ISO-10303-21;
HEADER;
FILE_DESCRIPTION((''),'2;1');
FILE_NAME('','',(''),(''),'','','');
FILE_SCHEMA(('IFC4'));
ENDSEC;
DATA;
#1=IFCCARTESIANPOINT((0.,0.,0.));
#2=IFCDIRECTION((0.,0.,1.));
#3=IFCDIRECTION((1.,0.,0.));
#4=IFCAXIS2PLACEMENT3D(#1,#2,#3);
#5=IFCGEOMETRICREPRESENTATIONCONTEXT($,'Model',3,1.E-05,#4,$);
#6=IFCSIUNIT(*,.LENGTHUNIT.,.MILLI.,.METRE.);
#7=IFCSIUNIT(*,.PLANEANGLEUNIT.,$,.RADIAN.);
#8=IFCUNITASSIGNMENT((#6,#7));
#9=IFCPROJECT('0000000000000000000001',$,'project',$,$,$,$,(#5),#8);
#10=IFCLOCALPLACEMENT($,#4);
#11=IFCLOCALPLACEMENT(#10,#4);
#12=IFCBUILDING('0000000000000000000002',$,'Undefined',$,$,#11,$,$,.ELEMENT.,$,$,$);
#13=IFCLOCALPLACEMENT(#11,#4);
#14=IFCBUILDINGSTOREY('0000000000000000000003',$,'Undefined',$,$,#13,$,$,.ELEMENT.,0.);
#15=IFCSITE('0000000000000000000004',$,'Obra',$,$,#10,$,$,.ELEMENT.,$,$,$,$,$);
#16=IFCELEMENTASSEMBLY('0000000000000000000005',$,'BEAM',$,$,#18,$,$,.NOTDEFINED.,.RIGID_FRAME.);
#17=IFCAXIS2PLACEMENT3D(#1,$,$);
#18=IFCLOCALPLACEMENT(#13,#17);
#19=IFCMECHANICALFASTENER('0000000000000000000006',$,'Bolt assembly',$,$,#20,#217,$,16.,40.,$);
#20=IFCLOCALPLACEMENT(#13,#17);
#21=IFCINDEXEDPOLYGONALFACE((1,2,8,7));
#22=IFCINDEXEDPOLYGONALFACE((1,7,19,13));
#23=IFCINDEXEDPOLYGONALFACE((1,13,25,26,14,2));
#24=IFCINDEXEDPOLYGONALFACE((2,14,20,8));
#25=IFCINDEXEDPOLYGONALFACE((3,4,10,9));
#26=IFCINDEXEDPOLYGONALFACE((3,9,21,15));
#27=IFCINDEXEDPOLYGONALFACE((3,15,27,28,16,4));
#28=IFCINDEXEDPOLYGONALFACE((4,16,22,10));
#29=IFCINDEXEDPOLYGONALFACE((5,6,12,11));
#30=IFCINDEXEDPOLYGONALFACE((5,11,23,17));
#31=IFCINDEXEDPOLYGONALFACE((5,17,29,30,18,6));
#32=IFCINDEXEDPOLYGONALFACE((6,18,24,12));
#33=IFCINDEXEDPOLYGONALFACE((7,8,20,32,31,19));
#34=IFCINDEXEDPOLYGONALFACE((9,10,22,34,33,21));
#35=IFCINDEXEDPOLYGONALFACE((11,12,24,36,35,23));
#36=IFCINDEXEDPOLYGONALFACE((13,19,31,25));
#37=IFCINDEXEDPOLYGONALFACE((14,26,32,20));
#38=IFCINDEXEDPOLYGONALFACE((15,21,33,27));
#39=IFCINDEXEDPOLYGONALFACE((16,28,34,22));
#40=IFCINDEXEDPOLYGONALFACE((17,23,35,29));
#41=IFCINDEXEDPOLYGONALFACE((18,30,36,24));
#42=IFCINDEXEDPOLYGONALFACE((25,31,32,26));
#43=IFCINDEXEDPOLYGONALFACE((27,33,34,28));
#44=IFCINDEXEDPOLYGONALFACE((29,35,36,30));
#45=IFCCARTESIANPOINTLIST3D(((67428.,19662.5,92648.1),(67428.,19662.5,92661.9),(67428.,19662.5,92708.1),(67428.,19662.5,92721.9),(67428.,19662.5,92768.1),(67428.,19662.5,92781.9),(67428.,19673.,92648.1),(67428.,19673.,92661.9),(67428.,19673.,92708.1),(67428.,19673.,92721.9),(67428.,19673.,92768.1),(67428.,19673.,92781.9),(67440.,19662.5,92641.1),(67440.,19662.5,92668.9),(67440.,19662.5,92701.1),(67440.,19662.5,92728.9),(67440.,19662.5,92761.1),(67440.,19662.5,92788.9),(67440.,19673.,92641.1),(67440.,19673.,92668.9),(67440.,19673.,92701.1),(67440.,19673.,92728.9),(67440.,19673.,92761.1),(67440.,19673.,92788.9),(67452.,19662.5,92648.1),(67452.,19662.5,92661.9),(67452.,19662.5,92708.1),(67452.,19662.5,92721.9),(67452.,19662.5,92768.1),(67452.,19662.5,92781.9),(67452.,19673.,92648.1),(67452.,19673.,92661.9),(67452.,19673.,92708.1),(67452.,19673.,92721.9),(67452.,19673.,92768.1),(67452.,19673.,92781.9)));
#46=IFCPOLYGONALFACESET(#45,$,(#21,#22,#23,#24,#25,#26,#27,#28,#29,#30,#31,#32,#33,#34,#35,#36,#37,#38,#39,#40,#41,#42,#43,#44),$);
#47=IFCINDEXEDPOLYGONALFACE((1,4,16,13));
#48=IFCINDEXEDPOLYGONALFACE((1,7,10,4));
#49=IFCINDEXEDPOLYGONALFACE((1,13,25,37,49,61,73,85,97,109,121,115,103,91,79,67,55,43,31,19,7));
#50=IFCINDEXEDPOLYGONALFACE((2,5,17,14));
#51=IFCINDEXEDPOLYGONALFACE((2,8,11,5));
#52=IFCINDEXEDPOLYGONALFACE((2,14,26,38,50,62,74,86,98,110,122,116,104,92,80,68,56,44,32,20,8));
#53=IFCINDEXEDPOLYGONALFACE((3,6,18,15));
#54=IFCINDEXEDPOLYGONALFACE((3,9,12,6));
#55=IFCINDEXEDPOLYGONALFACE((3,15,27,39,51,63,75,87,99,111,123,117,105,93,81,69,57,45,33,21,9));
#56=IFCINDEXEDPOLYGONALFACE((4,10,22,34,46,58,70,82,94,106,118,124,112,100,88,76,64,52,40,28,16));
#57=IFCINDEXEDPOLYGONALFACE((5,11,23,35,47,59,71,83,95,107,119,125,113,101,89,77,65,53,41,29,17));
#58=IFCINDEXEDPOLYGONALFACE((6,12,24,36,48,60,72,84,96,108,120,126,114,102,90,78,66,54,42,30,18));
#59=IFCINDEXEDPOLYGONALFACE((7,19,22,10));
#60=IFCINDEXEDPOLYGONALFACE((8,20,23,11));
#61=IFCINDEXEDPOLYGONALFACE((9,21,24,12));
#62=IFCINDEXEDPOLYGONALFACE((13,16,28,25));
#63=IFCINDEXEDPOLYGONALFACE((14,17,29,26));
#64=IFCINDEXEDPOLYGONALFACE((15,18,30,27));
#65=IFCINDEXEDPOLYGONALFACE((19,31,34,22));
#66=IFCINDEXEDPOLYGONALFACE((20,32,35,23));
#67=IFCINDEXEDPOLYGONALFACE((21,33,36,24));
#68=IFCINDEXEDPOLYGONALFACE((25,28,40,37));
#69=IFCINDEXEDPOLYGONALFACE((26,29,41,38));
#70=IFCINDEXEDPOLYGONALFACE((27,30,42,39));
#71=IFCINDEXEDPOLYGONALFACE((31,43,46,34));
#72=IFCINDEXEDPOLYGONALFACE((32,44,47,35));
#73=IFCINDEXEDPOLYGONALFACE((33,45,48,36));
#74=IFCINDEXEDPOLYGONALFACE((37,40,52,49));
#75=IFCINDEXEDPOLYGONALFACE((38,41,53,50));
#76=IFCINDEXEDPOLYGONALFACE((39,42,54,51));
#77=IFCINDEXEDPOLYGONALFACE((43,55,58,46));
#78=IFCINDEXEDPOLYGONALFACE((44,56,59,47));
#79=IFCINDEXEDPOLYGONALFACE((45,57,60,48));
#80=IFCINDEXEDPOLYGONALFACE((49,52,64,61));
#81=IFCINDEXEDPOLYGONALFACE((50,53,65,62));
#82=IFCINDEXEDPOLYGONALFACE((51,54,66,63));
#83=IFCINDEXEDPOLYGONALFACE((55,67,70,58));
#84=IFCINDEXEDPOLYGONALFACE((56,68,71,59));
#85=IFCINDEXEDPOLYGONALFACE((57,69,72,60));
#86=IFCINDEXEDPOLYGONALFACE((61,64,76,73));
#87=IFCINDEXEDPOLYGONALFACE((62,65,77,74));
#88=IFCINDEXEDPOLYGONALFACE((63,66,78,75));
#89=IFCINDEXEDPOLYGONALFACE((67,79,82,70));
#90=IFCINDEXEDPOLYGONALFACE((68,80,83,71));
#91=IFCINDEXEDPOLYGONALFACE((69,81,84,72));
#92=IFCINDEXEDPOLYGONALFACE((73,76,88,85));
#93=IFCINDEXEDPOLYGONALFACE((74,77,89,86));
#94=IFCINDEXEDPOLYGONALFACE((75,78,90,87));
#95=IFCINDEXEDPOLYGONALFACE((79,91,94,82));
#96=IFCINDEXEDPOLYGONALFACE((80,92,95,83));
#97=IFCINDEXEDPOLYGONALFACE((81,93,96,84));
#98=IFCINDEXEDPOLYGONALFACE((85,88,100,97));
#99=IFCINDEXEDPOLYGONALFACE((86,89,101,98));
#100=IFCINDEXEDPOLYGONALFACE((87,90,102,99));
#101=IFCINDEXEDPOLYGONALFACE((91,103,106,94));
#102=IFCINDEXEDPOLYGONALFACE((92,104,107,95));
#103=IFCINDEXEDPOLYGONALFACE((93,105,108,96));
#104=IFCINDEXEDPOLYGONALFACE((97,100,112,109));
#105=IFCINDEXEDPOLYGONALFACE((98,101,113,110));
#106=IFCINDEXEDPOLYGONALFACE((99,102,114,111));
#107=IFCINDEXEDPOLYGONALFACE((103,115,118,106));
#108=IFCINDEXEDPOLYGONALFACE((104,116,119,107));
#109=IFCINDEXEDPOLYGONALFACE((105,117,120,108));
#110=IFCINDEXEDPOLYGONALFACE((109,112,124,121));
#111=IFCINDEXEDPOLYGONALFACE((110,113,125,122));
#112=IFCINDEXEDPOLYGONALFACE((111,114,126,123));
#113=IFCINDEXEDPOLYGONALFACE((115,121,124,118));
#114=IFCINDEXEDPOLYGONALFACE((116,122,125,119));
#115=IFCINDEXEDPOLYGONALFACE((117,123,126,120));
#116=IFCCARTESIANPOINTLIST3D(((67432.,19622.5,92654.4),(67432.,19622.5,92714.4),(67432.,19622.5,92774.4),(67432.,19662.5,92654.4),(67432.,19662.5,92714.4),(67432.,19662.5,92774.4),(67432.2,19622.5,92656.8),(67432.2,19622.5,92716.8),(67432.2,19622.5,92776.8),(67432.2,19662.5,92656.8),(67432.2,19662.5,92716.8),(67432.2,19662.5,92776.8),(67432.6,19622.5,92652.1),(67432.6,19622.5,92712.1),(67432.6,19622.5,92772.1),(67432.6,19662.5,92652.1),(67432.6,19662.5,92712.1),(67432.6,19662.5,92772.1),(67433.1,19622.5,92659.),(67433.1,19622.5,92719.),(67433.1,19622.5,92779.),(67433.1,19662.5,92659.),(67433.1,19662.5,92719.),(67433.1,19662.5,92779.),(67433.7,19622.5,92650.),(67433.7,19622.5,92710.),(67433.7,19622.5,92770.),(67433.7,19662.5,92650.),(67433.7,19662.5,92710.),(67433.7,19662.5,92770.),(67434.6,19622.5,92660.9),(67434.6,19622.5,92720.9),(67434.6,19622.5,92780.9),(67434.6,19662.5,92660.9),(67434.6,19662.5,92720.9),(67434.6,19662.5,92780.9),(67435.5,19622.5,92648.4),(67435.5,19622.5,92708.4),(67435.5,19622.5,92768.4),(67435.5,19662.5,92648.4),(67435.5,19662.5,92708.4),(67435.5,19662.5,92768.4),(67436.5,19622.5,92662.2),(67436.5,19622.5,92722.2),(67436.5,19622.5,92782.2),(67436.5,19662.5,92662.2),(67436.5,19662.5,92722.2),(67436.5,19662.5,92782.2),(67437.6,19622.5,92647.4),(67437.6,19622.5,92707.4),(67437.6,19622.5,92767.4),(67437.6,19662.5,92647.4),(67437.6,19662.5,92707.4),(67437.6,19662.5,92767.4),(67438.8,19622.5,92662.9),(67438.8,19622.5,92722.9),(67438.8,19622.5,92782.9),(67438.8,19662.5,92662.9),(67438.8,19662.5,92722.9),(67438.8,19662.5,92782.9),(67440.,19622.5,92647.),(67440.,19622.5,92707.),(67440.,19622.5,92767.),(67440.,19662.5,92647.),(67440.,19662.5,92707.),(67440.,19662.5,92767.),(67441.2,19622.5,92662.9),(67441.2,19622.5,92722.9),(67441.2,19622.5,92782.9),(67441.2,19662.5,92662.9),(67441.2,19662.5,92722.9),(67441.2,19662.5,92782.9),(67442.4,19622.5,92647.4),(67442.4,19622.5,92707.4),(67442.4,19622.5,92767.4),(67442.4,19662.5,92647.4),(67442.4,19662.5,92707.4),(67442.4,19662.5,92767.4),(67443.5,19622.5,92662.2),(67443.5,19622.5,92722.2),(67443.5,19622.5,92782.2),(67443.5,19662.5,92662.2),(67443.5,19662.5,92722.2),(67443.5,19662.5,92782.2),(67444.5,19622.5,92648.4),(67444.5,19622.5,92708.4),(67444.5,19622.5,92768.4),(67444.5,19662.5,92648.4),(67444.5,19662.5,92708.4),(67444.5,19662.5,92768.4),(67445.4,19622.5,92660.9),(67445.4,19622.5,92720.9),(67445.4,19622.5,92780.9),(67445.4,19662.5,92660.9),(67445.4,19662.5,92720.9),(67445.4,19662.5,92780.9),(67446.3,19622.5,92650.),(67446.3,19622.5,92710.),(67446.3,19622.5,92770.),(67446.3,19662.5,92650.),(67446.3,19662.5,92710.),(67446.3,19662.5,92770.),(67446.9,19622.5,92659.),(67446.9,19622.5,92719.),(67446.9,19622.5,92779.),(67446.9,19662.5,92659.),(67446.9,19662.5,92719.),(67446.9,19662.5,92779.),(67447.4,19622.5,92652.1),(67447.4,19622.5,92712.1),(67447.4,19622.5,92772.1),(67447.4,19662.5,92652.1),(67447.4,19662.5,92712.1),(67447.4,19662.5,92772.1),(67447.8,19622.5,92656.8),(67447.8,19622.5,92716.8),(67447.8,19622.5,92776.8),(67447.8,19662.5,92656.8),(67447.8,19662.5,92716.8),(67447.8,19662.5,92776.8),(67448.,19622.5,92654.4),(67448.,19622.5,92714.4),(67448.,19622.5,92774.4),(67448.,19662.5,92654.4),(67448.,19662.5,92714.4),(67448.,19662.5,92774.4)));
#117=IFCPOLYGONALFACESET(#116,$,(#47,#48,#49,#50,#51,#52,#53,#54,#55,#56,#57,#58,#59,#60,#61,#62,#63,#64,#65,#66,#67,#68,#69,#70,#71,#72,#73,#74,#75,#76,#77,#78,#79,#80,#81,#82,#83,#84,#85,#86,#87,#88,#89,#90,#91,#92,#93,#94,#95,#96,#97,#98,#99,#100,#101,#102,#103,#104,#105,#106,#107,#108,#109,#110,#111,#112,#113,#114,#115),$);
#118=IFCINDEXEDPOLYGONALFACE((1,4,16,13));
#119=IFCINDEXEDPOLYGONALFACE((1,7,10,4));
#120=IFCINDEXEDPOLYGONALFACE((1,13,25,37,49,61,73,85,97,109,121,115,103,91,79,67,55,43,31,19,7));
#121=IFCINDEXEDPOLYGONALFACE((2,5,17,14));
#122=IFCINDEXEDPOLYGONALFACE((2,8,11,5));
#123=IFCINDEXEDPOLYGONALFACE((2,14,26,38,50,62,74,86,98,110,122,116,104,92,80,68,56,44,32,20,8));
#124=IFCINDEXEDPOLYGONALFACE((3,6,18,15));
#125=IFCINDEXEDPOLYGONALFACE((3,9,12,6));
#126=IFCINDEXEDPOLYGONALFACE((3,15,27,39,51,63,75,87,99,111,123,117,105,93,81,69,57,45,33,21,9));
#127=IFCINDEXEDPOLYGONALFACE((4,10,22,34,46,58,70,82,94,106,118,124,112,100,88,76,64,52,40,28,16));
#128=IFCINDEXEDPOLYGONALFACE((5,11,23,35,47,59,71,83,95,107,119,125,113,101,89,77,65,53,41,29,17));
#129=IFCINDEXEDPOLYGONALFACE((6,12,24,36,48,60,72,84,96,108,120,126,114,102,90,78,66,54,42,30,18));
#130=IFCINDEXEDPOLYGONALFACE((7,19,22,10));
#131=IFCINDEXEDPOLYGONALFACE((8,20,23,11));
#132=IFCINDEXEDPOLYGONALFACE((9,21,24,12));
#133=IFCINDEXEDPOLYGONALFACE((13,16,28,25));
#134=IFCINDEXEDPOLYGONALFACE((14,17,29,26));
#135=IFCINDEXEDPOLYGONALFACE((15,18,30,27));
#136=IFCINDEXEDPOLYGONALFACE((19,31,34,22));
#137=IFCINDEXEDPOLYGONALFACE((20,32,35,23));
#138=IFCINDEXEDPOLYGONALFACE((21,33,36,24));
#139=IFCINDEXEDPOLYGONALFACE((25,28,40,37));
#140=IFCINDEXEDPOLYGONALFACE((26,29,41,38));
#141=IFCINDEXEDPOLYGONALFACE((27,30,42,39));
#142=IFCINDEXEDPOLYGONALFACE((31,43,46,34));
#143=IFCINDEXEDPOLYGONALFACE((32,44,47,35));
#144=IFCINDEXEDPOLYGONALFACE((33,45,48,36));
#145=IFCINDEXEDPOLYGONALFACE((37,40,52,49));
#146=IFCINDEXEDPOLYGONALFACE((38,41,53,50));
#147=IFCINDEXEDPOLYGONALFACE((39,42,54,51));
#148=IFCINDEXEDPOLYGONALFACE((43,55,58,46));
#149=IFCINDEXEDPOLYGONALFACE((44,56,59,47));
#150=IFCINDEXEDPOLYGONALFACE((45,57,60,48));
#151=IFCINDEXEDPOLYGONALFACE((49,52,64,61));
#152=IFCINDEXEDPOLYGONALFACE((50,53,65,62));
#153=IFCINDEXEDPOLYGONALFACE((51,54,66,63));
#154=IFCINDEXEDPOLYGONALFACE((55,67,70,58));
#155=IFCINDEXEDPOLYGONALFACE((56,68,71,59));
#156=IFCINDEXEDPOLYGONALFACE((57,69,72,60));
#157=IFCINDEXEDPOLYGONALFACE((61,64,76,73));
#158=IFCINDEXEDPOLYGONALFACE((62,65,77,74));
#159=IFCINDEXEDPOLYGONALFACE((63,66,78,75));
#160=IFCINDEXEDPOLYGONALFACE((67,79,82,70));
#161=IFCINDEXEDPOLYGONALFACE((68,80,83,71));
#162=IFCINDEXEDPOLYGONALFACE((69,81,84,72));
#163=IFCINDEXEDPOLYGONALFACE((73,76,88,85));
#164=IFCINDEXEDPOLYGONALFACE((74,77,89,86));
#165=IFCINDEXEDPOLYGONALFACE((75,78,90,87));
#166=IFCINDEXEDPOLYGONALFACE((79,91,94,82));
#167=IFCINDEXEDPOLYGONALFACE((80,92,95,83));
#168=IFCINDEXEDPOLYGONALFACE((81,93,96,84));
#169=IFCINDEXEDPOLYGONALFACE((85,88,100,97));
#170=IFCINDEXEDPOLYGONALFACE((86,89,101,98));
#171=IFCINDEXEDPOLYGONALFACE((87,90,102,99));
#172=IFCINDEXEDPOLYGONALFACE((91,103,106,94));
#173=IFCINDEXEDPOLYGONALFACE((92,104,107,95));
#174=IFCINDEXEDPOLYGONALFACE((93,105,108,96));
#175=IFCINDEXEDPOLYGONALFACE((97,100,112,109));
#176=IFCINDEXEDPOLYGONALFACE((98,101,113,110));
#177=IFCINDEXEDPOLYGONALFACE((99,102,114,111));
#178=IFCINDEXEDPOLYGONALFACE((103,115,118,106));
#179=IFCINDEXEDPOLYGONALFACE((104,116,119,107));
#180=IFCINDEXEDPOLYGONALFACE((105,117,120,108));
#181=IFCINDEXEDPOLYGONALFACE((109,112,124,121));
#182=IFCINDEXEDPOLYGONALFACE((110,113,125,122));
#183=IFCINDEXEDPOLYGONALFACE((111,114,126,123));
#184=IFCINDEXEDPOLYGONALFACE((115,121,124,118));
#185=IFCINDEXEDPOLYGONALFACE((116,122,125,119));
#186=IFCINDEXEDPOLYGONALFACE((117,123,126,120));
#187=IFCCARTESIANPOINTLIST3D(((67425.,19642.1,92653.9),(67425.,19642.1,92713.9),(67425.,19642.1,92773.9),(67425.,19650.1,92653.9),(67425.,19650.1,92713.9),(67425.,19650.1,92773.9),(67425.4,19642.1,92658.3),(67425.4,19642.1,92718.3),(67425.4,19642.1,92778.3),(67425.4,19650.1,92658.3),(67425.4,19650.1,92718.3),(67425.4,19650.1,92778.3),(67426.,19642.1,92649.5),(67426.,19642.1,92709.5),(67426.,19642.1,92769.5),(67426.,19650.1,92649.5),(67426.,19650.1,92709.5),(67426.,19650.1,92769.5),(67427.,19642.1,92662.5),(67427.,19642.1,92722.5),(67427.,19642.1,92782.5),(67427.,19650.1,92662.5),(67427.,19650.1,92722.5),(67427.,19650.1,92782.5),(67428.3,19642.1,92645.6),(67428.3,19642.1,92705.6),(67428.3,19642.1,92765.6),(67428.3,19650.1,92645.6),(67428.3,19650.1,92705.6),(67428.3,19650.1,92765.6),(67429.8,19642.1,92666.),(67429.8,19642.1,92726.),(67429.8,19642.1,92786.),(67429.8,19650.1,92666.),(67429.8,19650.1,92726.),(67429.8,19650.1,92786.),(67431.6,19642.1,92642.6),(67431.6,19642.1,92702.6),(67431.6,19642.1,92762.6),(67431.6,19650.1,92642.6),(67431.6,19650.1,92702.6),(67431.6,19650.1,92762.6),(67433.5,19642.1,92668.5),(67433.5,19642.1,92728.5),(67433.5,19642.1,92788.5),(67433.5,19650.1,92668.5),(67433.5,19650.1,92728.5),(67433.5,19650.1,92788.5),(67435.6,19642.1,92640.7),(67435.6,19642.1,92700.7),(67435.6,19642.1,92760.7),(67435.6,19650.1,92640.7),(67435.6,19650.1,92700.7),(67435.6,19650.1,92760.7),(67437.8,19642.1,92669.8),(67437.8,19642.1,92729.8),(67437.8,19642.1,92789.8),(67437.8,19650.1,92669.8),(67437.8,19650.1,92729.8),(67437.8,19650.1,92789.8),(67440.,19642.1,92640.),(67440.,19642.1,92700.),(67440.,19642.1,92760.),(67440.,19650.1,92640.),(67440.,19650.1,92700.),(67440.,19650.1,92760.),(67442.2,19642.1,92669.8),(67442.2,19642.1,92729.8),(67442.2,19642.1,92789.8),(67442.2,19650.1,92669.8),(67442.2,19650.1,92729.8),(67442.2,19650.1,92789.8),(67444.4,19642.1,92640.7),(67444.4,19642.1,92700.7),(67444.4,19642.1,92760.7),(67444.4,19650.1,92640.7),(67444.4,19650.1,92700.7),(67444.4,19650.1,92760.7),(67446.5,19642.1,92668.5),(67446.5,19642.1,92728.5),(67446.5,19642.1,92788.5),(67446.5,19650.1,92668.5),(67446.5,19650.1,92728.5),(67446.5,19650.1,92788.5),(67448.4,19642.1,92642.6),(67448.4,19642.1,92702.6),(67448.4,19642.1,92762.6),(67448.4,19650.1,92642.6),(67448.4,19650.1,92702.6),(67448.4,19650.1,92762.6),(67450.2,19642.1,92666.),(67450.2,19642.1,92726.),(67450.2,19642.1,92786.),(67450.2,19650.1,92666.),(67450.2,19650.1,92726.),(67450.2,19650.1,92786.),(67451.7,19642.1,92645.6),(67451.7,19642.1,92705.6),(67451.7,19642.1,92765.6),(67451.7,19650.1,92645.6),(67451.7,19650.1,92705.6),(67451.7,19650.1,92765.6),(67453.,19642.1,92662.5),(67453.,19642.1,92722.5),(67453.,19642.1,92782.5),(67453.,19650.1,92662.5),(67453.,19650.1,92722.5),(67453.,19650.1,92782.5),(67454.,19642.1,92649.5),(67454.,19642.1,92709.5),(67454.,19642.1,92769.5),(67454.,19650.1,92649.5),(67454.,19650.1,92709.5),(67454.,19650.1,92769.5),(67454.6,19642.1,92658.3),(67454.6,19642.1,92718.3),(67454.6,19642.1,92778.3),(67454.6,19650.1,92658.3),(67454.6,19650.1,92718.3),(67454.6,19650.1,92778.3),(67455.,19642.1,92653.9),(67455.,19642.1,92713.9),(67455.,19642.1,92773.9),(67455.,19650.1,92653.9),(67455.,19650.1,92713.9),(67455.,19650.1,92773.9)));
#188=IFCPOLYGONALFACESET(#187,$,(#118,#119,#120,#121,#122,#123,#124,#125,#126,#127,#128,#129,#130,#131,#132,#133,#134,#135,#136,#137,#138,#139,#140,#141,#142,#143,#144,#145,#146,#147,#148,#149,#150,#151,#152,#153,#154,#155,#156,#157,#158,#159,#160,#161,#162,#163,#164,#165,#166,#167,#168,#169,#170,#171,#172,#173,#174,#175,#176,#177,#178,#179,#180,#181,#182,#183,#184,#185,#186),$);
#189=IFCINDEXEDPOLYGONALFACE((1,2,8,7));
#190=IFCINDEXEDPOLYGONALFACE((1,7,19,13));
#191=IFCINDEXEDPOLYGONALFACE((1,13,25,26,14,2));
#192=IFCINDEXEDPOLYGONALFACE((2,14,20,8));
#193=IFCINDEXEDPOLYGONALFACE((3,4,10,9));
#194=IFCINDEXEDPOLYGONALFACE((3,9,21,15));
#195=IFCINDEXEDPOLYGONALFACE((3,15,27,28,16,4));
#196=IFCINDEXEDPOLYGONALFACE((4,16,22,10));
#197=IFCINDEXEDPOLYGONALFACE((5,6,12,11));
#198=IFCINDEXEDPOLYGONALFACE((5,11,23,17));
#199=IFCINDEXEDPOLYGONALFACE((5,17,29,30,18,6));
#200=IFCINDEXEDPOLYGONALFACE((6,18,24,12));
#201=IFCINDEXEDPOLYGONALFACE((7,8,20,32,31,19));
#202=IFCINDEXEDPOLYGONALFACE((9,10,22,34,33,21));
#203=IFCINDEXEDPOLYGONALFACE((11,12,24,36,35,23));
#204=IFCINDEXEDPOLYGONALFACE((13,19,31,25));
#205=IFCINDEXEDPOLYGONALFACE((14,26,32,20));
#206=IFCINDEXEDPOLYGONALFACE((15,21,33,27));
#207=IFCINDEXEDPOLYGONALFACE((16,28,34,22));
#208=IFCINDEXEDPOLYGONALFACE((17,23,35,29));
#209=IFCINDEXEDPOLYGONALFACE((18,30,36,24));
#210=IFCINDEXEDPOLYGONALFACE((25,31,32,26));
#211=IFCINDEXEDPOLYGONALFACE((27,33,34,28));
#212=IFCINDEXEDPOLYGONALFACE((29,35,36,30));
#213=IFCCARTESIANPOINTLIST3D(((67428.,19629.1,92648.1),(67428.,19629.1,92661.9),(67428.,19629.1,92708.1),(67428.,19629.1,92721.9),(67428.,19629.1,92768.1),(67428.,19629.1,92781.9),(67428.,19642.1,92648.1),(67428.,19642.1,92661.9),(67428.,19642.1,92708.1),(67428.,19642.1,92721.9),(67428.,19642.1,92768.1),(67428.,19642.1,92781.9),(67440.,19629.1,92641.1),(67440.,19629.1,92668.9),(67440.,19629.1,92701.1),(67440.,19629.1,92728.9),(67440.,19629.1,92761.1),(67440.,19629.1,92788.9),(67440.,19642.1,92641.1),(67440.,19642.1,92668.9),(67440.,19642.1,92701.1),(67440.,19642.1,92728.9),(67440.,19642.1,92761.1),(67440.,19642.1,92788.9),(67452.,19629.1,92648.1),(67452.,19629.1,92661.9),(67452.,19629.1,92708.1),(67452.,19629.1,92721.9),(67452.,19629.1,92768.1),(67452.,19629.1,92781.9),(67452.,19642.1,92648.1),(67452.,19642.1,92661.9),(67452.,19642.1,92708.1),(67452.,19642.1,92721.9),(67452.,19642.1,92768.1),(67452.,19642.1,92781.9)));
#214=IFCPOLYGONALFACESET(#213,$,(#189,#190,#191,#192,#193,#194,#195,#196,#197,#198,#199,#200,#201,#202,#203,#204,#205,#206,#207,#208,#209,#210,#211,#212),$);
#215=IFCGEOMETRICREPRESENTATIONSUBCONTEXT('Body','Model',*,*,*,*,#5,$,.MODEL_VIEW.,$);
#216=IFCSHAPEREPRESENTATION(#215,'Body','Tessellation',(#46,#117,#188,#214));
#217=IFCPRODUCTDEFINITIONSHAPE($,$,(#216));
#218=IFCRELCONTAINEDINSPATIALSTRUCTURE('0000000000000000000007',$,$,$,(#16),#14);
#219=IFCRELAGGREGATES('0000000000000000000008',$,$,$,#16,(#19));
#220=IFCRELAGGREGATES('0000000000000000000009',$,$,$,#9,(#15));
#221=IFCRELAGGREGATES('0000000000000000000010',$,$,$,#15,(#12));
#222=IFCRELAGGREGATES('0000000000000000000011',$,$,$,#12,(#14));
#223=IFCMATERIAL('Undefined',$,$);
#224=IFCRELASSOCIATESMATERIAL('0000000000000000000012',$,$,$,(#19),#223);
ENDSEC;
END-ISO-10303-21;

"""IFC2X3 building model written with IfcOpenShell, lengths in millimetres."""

from ifc_helpers import new_model, si_unit, frame, origin_with_axes, origin_2d_with_axis, place, context, subcontext, project, spatial, polyline, circle, outline, extrude, source, transform, mapped, material, element, aggregate, save


model = new_model("IFC2X3")

# Units and contexts
model_context = context("Model", 3, precision=1e-05, world=origin_with_axes())
body_context = subcontext(model_context, "Body", "Model", "MODEL_VIEW")
ifc_project = project(units=[si_unit("LENGTHUNIT", "METRE", prefix="MILLI"), si_unit("PLANEANGLEUNIT", "RADIAN")], contexts=[model_context])

# Site, building, storey
site_placement = place(None, origin_with_axes())
site = spatial("IfcSite", under=ifc_project, at=site_placement, Name="Obra", CompositionType="ELEMENT")
building_placement = place(site_placement, origin_with_axes())
building = spatial("IfcBuilding", under=site, at=building_placement, Name="Undefined", CompositionType="ELEMENT")
storey_placement = place(building_placement, origin_with_axes())
storey = spatial("IfcBuildingStorey", under=building, at=storey_placement, Name="Undefined", CompositionType="ELEMENT", Elevation=0.0)

# Shared definitions
ifc_material_1 = material(Name="Undefined")

# Element assembly, mechanical fastener
assembly_1_placement = place(storey_placement, origin_with_axes())
assembly_1 = element("IfcElementAssembly", 1, at=assembly_1_placement, inside=storey, Name="BEAM", AssemblyPlace="NOTDEFINED", PredefinedType="RIGID_FRAME")
shared_shape_1 = source(origin_with_axes(), body_context, "Body", "SweptSolid", [
    extrude(outline(polyline([(13.9, 0.0), (6.9, 12.0), (-6.9, 12.0), (-13.9, 0.0), (-6.9, -12.0), (6.9, -12.0), (13.9, 0.0)])), frame((0.0, -19.7, 0.0), z_axis=(0.0, 1.0, 0.0), x_axis=(1.0, 0.0, 0.0)), (0.0, 0.0, 1.0), 10.6),
    extrude(circle(Radius=8.0, at=origin_2d_with_axis()), frame((0.0, -9.1, 0.0), z_axis=(0.0, 1.0, 0.0), x_axis=(1.0, 0.0, 0.0)), (0.0, 0.0, 1.0), 40.0),
    extrude(circle(Radius=15.0, at=origin_2d_with_axis()), frame((0.0, 3.3, 0.0), z_axis=(0.0, 1.0, 0.0), x_axis=(1.0, 0.0, 0.0)), (0.0, 0.0, 1.0), 8.0),
    extrude(outline(polyline([(13.9, 0.0), (6.9, 12.0), (-6.9, 12.0), (-13.9, 0.0), (-6.9, -12.0), (6.9, -12.0), (13.9, 0.0)])), frame((0.0, 11.3, 0.0), z_axis=(0.0, 1.0, 0.0), x_axis=(1.0, 0.0, 0.0)), (0.0, 0.0, 1.0), 13.0),
])
mechanical_fastener_1_placement = place(assembly_1_placement, frame((67490.0, 19653.4, 92835.0), z_axis=(-1.0, 0.0, 0.0), x_axis=(0.0, 0.0, -1.0)))
mechanical_fastener_1 = element("IfcMechanicalFastener", 2, at=mechanical_fastener_1_placement, material=ifc_material_1, Name="Bolt assembly", NominalDiameter=16.0, NominalLength=40.0, context=body_context, shape_type="MappedRepresentation", body=[
    mapped(shared_shape_1, transform((60.0, 0.0, 50.0))),
    mapped(shared_shape_1, transform((120.0, 0.0, 50.0))),
    mapped(shared_shape_1, transform((180.0, 0.0, 50.0))),
])
aggregate(assembly_1, [mechanical_fastener_1])

save(model, "model.ifc")
